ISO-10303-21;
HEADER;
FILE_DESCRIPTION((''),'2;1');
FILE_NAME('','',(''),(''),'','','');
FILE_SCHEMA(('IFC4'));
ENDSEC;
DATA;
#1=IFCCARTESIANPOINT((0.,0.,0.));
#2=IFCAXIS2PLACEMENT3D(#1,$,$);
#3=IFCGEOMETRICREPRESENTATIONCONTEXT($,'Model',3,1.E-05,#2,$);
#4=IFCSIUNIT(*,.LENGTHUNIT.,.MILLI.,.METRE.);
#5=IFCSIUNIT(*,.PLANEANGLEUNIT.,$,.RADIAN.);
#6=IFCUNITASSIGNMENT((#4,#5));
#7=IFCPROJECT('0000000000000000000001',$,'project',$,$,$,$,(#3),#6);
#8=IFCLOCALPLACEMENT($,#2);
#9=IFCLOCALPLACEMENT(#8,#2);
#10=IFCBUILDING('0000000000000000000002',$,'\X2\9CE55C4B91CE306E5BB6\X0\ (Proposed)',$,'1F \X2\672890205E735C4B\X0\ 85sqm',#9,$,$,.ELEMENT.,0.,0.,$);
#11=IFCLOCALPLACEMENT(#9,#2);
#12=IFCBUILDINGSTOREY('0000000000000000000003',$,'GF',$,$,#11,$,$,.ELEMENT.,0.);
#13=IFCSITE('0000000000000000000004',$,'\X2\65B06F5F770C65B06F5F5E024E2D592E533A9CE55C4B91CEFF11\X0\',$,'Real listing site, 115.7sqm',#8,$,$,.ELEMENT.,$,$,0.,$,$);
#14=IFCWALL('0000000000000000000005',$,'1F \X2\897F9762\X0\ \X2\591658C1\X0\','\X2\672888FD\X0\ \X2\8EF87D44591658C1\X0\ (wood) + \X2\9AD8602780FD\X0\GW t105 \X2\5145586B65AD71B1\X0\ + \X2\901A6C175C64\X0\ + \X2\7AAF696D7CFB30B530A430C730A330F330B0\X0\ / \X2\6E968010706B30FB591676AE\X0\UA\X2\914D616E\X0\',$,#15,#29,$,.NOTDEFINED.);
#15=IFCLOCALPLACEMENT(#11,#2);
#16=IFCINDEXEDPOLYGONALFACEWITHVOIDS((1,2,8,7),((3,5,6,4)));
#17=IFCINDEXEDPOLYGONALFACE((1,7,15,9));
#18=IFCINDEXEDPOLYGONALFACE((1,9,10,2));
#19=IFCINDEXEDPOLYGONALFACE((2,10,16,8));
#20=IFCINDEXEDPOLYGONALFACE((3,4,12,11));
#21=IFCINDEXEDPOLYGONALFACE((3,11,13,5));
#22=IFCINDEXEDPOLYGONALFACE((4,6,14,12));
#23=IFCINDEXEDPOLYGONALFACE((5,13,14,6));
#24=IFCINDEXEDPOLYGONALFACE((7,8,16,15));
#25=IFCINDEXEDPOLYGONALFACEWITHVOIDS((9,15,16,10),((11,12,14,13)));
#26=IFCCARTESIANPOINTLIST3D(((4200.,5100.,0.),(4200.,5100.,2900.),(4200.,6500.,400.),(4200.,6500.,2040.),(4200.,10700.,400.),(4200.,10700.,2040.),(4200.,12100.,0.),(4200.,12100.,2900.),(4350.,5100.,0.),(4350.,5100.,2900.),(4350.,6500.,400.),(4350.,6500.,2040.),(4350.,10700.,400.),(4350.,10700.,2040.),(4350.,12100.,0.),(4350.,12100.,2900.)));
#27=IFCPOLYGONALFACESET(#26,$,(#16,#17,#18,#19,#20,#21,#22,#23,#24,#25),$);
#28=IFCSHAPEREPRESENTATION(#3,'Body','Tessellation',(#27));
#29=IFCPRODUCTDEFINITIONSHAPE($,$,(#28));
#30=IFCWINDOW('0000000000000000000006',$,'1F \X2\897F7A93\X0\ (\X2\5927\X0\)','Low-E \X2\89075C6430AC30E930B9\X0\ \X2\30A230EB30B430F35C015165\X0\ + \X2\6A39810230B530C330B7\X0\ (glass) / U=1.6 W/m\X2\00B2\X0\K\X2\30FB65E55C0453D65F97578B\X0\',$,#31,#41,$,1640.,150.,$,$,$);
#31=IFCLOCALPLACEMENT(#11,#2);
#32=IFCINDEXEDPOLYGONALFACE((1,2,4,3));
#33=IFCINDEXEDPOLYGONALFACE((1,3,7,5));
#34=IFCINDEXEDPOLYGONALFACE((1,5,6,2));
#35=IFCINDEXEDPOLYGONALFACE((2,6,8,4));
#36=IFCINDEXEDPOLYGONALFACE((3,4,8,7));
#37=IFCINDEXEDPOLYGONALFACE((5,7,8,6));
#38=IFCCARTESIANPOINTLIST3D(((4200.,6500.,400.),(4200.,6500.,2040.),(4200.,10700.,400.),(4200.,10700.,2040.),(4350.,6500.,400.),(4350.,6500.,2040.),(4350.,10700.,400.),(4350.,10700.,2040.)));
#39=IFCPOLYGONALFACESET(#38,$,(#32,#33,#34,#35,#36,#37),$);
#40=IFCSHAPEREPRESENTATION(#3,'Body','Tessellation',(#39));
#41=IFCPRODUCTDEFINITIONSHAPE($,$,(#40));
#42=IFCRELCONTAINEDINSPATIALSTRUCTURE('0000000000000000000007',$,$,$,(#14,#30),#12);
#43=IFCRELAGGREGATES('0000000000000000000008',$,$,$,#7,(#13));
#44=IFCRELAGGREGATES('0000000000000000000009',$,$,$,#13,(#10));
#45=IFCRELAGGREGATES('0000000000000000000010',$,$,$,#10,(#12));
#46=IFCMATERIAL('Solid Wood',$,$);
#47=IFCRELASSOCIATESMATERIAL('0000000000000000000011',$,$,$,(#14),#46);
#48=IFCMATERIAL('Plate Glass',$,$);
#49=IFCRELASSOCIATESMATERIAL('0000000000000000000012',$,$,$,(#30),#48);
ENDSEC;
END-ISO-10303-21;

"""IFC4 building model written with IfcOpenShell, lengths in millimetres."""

from ifc_helpers import new_model, si_unit, frame, frame_2d, origin, place, context, project, spatial, rectangle, extrude, material, element, fill, save


model = new_model("IFC4")

# Units and contexts
model_context = context("Model", 3, precision=1e-05, world=origin())
ifc_project = project(units=[si_unit("LENGTHUNIT", "METRE", prefix="MILLI"), si_unit("PLANEANGLEUNIT", "RADIAN")], contexts=[model_context])

# Site, building, storey
site_placement = place(None, origin())
site = spatial("IfcSite", under=ifc_project, at=site_placement, Name="新潟県新潟市中央区鳥屋野１", ObjectType="Real listing site, 115.7sqm", CompositionType="ELEMENT", RefElevation=0.0)
building_placement = place(site_placement, origin())
building = spatial("IfcBuilding", under=site, at=building_placement, Name="鳥屋野の家 (Proposed)", ObjectType="1F 木造平屋 85sqm", CompositionType="ELEMENT", ElevationOfRefHeight=0.0, ElevationOfTerrain=0.0)
storey_placement = place(building_placement, origin())
storey = spatial("IfcBuildingStorey", under=building, at=storey_placement, Name="GF", CompositionType="ELEMENT", Elevation=0.0)

# Shared definitions
ifc_material_1 = material(Name="Solid Wood")

# Shared definitions
ifc_material_2 = material(Name="Plate Glass")

# Wall, opening, window
wall_1_placement = place(storey_placement, frame((2100.0, 2550.0, 0.0)))
wall_1 = element("IfcWall", 1, at=wall_1_placement, inside=storey, material=ifc_material_1, Name="1F 西面 外壁", Description="木製 軸組外壁 (wood) + 高性能GW t105 充填断熱 + 通気層 + 窯業系サイディング / 準耐火・外皮UA配慮", PredefinedType="NOTDEFINED", context=model_context, shape_type="SweptSolid", body=[
    extrude(rectangle(XDim=150.0, YDim=7000.0, at=frame_2d((75.0, 3500.0))), frame((2100.0, 2550.0, 0.0)), (0.0, 0.0, 1.0), 2900.0),
])
opening_1_placement = place(storey_placement, frame((2100.0, 3250.0, 200.0)))
opening_1 = element("IfcOpeningElement", 2, at=opening_1_placement, cuts=wall_1, PredefinedType="NOTDEFINED", context=model_context, shape_type="SweptSolid", body=[
    extrude(rectangle(XDim=150.0, YDim=4200.0, at=frame_2d((75.0, 2100.0))), frame((2100.0, 3250.0, 200.0)), (0.0, 0.0, 1.0), 1640.0),
])
window_1_placement = place(storey_placement, frame((2100.0, 3250.0, 200.0)))
window_1 = element("IfcWindow", 3, at=window_1_placement, inside=storey, material=ifc_material_2, Name="1F 西窓 (大)", Description="Low-E 複層ガラス アルゴン封入 + 樹脂サッシ (glass) / U=1.6 W/m²K・日射取得型", OverallHeight=1640.0, OverallWidth=150.0, context=model_context, shape_type="SweptSolid", body=[
    extrude(rectangle(XDim=150.0, YDim=4200.0, at=frame_2d((75.0, 2100.0))), frame((2100.0, 3250.0, 200.0)), (0.0, 0.0, 1.0), 1640.0),
])
fill(opening_1, window_1)

save(model, "model.ifc")
